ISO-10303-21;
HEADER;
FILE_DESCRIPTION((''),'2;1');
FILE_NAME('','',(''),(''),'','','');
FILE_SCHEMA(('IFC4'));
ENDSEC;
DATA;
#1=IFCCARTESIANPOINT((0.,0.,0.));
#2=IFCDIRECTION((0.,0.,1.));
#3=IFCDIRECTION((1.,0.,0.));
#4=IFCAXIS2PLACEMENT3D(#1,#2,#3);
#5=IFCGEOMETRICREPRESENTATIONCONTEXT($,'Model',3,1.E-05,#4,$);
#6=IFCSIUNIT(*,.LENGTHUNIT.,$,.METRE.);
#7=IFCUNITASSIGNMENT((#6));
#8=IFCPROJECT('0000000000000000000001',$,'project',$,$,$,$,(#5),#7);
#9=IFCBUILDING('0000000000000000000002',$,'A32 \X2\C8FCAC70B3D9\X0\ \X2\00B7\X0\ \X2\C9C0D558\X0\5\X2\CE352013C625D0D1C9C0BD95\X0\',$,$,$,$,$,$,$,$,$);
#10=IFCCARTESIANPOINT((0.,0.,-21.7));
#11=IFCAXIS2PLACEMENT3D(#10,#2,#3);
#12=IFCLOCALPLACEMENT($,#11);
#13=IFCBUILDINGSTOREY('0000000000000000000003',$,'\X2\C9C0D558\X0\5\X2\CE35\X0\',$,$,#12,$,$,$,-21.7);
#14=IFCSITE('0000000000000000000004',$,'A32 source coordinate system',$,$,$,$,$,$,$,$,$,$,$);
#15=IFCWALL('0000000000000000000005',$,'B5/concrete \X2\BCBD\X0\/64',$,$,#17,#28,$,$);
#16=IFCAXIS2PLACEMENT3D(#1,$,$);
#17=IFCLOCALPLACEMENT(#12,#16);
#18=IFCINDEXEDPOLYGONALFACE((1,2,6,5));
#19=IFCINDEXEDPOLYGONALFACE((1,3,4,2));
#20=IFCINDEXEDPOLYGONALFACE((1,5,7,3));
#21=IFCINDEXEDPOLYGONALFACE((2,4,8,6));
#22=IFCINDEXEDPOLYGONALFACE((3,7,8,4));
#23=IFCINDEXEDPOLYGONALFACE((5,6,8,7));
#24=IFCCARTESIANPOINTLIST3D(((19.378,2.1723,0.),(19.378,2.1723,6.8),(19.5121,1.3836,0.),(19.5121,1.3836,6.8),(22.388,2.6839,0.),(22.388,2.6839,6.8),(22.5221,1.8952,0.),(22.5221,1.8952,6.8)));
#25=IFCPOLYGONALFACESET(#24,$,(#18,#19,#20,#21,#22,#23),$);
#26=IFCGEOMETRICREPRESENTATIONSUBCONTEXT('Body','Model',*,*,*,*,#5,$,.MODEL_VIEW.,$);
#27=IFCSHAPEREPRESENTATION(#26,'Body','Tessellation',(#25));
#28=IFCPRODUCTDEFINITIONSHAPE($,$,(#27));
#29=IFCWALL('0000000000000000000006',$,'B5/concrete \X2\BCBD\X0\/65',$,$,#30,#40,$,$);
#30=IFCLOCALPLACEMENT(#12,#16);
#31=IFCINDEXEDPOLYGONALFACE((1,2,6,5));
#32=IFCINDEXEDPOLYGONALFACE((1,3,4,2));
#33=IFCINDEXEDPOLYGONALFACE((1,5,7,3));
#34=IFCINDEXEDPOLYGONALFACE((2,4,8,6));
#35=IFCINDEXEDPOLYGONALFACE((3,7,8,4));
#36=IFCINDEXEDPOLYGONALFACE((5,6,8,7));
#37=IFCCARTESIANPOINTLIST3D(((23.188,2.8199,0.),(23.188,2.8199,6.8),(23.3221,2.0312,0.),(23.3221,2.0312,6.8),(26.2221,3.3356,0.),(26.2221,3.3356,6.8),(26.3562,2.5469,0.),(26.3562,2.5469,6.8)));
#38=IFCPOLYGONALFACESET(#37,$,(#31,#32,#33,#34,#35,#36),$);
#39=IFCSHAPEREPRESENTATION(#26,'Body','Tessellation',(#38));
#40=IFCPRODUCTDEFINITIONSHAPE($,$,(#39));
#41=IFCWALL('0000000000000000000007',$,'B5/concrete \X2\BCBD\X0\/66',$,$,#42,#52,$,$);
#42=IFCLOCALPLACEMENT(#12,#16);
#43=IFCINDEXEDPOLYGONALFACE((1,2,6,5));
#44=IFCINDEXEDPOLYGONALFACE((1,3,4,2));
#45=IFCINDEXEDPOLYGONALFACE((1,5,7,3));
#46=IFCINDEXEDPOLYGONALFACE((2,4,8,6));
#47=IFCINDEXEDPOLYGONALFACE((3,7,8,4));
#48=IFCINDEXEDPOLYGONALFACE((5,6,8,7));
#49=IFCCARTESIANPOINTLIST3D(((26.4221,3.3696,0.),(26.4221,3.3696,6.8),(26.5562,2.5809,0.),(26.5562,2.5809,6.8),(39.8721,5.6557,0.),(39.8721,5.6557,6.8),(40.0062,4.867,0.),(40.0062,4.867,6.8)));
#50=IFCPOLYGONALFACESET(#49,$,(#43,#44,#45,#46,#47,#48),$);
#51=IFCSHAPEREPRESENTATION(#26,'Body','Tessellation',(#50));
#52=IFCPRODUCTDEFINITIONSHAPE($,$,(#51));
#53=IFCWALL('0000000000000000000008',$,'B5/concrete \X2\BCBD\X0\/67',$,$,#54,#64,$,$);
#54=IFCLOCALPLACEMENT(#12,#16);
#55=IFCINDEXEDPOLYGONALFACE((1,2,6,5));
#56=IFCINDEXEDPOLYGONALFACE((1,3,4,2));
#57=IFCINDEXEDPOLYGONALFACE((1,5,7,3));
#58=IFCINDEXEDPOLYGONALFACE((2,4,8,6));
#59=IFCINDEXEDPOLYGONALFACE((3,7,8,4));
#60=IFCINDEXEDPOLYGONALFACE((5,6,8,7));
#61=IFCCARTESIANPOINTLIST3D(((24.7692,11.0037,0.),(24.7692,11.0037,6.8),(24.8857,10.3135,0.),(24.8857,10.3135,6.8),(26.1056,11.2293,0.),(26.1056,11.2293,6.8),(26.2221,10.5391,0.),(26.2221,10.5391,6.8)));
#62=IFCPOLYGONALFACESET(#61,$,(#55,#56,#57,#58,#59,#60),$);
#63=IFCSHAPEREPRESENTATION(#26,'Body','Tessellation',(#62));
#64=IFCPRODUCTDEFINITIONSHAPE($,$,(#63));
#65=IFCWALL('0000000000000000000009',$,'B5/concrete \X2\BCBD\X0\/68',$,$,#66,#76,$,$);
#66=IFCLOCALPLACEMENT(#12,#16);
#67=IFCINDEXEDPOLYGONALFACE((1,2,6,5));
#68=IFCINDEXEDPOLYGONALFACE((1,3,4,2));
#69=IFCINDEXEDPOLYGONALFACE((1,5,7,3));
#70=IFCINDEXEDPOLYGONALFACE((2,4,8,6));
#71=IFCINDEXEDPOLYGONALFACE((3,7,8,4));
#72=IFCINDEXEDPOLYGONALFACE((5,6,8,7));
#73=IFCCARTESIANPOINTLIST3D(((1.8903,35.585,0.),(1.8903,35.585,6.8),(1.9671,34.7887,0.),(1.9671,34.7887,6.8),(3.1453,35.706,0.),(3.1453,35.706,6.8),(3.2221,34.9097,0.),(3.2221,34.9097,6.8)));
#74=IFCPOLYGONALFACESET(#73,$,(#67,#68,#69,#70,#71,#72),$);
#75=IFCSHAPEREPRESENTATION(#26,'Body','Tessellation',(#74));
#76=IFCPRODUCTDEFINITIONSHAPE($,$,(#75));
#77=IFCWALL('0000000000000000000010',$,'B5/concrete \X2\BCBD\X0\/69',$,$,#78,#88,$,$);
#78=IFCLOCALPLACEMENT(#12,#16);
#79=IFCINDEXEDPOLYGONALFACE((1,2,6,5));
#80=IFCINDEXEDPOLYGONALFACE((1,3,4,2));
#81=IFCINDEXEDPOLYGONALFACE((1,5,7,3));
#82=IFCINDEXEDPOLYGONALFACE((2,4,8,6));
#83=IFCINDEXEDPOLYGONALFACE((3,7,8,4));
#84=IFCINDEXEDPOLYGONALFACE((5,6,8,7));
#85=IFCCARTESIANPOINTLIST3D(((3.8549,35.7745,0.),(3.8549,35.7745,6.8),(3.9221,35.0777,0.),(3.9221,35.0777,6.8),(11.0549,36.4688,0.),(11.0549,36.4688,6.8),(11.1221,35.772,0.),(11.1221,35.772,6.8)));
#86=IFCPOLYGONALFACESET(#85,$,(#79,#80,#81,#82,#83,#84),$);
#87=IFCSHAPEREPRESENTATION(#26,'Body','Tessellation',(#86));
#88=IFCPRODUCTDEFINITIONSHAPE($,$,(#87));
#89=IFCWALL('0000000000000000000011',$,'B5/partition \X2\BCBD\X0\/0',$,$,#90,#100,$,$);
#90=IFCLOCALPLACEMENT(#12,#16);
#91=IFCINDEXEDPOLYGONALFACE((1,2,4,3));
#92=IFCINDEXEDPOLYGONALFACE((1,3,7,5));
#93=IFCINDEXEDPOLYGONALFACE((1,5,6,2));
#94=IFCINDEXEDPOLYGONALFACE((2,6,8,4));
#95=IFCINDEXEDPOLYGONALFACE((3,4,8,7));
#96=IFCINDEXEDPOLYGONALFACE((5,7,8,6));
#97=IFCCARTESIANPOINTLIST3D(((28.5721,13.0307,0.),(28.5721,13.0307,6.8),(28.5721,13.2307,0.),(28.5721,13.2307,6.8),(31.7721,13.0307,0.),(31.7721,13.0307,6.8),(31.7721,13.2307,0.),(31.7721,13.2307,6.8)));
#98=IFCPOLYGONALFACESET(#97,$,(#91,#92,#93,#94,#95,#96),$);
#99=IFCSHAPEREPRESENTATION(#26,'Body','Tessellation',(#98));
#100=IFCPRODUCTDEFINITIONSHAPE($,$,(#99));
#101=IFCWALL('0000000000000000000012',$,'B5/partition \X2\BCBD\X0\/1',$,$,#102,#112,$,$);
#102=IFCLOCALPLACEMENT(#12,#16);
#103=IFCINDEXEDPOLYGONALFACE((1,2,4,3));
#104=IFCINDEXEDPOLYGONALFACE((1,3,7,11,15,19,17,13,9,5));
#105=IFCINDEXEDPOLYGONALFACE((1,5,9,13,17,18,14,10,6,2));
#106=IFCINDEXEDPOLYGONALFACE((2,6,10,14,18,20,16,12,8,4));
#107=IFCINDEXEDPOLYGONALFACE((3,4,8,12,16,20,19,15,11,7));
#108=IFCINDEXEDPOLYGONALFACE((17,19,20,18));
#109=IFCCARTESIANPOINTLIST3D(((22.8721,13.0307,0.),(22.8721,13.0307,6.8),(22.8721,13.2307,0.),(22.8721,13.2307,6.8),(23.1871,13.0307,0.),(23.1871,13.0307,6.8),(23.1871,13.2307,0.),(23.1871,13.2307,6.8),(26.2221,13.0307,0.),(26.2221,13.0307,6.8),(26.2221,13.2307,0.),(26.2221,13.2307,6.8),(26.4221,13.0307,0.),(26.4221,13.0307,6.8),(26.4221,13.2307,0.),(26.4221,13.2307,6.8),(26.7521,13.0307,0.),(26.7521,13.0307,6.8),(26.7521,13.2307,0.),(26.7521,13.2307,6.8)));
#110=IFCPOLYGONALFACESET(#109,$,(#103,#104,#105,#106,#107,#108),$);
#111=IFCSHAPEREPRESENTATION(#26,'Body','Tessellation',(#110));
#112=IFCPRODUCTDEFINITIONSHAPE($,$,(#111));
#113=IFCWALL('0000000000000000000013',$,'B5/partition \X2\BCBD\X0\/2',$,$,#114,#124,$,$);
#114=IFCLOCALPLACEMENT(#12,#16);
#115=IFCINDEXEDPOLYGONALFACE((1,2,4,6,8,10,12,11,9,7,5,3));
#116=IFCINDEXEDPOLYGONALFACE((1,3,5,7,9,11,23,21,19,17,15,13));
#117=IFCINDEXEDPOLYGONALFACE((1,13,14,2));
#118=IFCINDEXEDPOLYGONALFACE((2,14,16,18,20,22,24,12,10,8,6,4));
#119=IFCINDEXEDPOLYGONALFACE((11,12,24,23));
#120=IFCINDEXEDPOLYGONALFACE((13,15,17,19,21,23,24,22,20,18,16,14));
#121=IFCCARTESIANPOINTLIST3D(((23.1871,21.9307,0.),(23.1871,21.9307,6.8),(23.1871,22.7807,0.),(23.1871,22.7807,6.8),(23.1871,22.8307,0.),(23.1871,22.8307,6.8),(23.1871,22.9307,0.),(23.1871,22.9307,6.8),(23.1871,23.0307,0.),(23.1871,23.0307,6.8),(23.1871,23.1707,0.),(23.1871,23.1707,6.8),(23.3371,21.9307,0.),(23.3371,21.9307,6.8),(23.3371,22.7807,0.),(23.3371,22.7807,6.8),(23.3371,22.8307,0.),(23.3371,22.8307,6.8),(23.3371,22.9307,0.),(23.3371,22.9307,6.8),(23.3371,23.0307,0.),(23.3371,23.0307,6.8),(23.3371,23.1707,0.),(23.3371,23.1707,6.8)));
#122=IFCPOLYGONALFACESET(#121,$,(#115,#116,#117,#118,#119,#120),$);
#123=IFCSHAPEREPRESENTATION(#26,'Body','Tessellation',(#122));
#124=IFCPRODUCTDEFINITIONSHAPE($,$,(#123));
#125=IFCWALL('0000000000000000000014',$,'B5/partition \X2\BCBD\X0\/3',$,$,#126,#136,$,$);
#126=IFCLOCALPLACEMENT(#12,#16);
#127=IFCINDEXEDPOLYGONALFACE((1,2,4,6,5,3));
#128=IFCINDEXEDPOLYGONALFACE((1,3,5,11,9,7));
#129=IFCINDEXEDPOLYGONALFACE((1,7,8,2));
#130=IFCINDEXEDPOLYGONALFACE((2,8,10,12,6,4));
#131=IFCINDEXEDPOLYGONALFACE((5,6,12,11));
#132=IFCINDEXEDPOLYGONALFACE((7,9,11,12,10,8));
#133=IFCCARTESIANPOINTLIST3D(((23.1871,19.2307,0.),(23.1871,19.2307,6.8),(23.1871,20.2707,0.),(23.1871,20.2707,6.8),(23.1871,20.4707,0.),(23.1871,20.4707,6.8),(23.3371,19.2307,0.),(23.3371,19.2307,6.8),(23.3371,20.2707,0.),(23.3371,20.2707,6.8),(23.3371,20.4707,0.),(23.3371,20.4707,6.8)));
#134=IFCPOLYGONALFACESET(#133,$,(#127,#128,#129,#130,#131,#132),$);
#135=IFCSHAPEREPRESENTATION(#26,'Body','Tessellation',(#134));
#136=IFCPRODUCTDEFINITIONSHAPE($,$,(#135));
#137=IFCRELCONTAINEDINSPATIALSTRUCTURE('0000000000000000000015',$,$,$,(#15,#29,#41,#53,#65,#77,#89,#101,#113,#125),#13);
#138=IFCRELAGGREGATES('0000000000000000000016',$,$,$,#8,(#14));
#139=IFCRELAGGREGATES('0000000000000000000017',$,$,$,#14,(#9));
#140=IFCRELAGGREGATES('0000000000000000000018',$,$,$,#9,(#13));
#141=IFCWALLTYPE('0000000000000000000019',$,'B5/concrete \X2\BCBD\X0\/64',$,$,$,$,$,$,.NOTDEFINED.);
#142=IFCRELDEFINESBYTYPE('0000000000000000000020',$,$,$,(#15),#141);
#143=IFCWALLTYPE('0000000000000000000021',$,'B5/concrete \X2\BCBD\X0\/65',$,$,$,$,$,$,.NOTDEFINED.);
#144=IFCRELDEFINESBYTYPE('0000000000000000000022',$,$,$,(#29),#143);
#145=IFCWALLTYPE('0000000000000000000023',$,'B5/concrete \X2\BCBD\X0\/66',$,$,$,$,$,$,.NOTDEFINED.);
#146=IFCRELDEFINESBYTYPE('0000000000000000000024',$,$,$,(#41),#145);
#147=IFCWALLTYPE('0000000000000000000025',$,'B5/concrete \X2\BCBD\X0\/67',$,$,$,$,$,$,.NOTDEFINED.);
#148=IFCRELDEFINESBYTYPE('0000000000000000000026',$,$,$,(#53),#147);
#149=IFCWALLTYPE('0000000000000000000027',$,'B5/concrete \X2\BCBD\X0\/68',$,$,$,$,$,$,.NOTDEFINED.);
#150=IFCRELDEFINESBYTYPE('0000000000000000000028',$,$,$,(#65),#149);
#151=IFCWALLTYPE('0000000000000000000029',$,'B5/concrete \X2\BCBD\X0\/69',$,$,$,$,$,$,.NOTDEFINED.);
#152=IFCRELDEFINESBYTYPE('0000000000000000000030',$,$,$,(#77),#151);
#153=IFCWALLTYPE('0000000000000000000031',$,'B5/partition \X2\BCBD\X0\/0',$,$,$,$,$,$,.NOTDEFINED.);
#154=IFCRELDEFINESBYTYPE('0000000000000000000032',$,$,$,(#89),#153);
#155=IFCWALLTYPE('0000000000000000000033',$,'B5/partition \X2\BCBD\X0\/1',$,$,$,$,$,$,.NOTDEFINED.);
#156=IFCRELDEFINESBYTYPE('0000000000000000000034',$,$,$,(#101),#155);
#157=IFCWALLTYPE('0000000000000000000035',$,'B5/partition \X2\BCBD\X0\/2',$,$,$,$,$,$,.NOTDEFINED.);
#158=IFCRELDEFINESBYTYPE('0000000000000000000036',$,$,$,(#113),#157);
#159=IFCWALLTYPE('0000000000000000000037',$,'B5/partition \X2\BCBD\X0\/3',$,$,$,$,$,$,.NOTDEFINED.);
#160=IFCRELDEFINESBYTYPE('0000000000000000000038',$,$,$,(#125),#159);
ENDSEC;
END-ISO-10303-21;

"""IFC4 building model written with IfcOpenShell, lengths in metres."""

from ifc_helpers import new_model, si_unit, frame, origin, origin_with_axes, place, context, subcontext, project, spatial, polyline, outline, extrude, source, transform, mapped, type_object, type_shapes, element, save


model = new_model("IFC4")

# Units and contexts
model_context = context("Model", 3, precision=1e-05, world=origin_with_axes())
body_context = subcontext(model_context, "Body", "Model", "MODEL_VIEW")
ifc_project = project(units=[si_unit("LENGTHUNIT", "METRE")], contexts=[model_context])

# Site, building, storey
site = spatial("IfcSite", under=ifc_project, Name="A32 source coordinate system")
building = spatial("IfcBuilding", under=site, Name="A32 주거동 · 지하5층–옥탑지붕")
storey_placement = place(None, frame((0.0, 0.0, -21.7), z_axis=(0.0, 0.0, 1.0), x_axis=(1.0, 0.0, 0.0)))
storey = spatial("IfcBuildingStorey", under=building, at=storey_placement, Name="지하5층", Elevation=-21.7)

# Walls
wall_type_1 = type_object("IfcWallType", Name="B5/concrete 벽/64", PredefinedType="NOTDEFINED")
shared_shape_1 = source(origin(), body_context, "Body", "SweptSolid", [
    extrude(outline(polyline([(19.5121, 1.3836), (19.378, 2.1723), (22.388, 2.6839), (22.5221, 1.8952), (19.5121, 1.3836)])), origin(), (0.0, 0.0, 1.0), 6.8),
])
type_shapes(wall_type_1, [shared_shape_1])
wall_1_placement = place(storey_placement, origin_with_axes())
element("IfcWall", 1, at=wall_1_placement, inside=storey, type_object=wall_type_1, Name="B5/concrete 벽/64", context=body_context, shape_type="MappedRepresentation", body=[
    mapped(shared_shape_1, transform((0.0, 0.0, 0.0), scale=1.0)),
])
wall_type_2 = type_object("IfcWallType", Name="B5/concrete 벽/65", PredefinedType="NOTDEFINED")
shared_shape_2 = source(origin(), body_context, "Body", "SweptSolid", [
    extrude(outline(polyline([(23.188, 2.8199), (26.2221, 3.3356), (26.3562, 2.5469), (23.3221, 2.0312), (23.188, 2.8199)])), origin(), (0.0, 0.0, 1.0), 6.8),
])
type_shapes(wall_type_2, [shared_shape_2])
wall_2_placement = place(storey_placement, origin_with_axes())
element("IfcWall", 2, at=wall_2_placement, inside=storey, type_object=wall_type_2, Name="B5/concrete 벽/65", context=body_context, shape_type="MappedRepresentation", body=[
    mapped(shared_shape_2, transform((0.0, 0.0, 0.0), scale=1.0)),
])
wall_type_3 = type_object("IfcWallType", Name="B5/concrete 벽/66", PredefinedType="NOTDEFINED")
shared_shape_3 = source(origin(), body_context, "Body", "SweptSolid", [
    extrude(outline(polyline([(26.4221, 3.3696), (39.8721, 5.6557), (40.0062, 4.867), (26.5562, 2.5809), (26.4221, 3.3696)])), origin(), (0.0, 0.0, 1.0), 6.8),
])
type_shapes(wall_type_3, [shared_shape_3])
wall_3_placement = place(storey_placement, origin_with_axes())
element("IfcWall", 3, at=wall_3_placement, inside=storey, type_object=wall_type_3, Name="B5/concrete 벽/66", context=body_context, shape_type="MappedRepresentation", body=[
    mapped(shared_shape_3, transform((0.0, 0.0, 0.0), scale=1.0)),
])
wall_type_4 = type_object("IfcWallType", Name="B5/concrete 벽/67", PredefinedType="NOTDEFINED")
shared_shape_4 = source(origin(), body_context, "Body", "SweptSolid", [
    extrude(outline(polyline([(24.7692, 11.0037), (26.1056, 11.2293), (26.2221, 10.5391), (24.8857, 10.3135), (24.7692, 11.0037)])), origin(), (0.0, 0.0, 1.0), 6.8),
])
type_shapes(wall_type_4, [shared_shape_4])
wall_4_placement = place(storey_placement, origin_with_axes())
element("IfcWall", 4, at=wall_4_placement, inside=storey, type_object=wall_type_4, Name="B5/concrete 벽/67", context=body_context, shape_type="MappedRepresentation", body=[
    mapped(shared_shape_4, transform((0.0, 0.0, 0.0), scale=1.0)),
])
wall_type_5 = type_object("IfcWallType", Name="B5/concrete 벽/68", PredefinedType="NOTDEFINED")
shared_shape_5 = source(origin(), body_context, "Body", "SweptSolid", [
    extrude(outline(polyline([(3.2221, 34.9097), (1.9671, 34.7887), (1.8903, 35.585), (3.1453, 35.706), (3.2221, 34.9097)])), origin(), (0.0, 0.0, 1.0), 6.8),
])
type_shapes(wall_type_5, [shared_shape_5])
wall_5_placement = place(storey_placement, origin_with_axes())
element("IfcWall", 5, at=wall_5_placement, inside=storey, type_object=wall_type_5, Name="B5/concrete 벽/68", context=body_context, shape_type="MappedRepresentation", body=[
    mapped(shared_shape_5, transform((0.0, 0.0, 0.0), scale=1.0)),
])
wall_type_6 = type_object("IfcWallType", Name="B5/concrete 벽/69", PredefinedType="NOTDEFINED")
shared_shape_6 = source(origin(), body_context, "Body", "SweptSolid", [
    extrude(outline(polyline([(3.9221, 35.0777), (3.8549, 35.7745), (11.0549, 36.4688), (11.1221, 35.772), (3.9221, 35.0777)])), origin(), (0.0, 0.0, 1.0), 6.8),
])
type_shapes(wall_type_6, [shared_shape_6])
wall_6_placement = place(storey_placement, origin_with_axes())
element("IfcWall", 6, at=wall_6_placement, inside=storey, type_object=wall_type_6, Name="B5/concrete 벽/69", context=body_context, shape_type="MappedRepresentation", body=[
    mapped(shared_shape_6, transform((0.0, 0.0, 0.0), scale=1.0)),
])
wall_type_7 = type_object("IfcWallType", Name="B5/partition 벽/0", PredefinedType="NOTDEFINED")
shared_shape_7 = source(origin(), body_context, "Body", "SweptSolid", [
    extrude(outline(polyline([(28.5721, 13.2307), (31.7721, 13.2307), (31.7721, 13.0307), (28.5721, 13.0307), (28.5721, 13.2307)])), origin(), (0.0, 0.0, 1.0), 6.8),
])
type_shapes(wall_type_7, [shared_shape_7])
wall_7_placement = place(storey_placement, origin_with_axes())
element("IfcWall", 7, at=wall_7_placement, inside=storey, type_object=wall_type_7, Name="B5/partition 벽/0", context=body_context, shape_type="MappedRepresentation", body=[
    mapped(shared_shape_7, transform((0.0, 0.0, 0.0), scale=1.0)),
])
wall_type_8 = type_object("IfcWallType", Name="B5/partition 벽/1", PredefinedType="NOTDEFINED")
shared_shape_8 = source(origin(), body_context, "Body", "SweptSolid", [
    extrude(outline(polyline([(26.2221, 13.2307), (26.4221, 13.2307), (26.7521, 13.2307), (26.7521, 13.0307), (26.4221, 13.0307), (26.2221, 13.0307), (23.1871, 13.0307), (22.8721, 13.0307), (22.8721, 13.2307), (23.1871, 13.2307), (26.2221, 13.2307)])), origin(), (0.0, 0.0, 1.0), 6.8),
])
type_shapes(wall_type_8, [shared_shape_8])
wall_8_placement = place(storey_placement, origin_with_axes())
element("IfcWall", 8, at=wall_8_placement, inside=storey, type_object=wall_type_8, Name="B5/partition 벽/1", context=body_context, shape_type="MappedRepresentation", body=[
    mapped(shared_shape_8, transform((0.0, 0.0, 0.0), scale=1.0)),
])
wall_type_9 = type_object("IfcWallType", Name="B5/partition 벽/2", PredefinedType="NOTDEFINED")
shared_shape_9 = source(origin(), body_context, "Body", "SweptSolid", [
    extrude(outline(polyline([(23.1871, 23.1707), (23.3371, 23.1707), (23.3371, 23.0307), (23.3371, 22.9307), (23.3371, 22.8307), (23.3371, 22.7807), (23.3371, 21.9307), (23.1871, 21.9307), (23.1871, 22.7807), (23.1871, 22.8307), (23.1871, 22.9307), (23.1871, 23.0307), (23.1871, 23.1707)])), origin(), (0.0, 0.0, 1.0), 6.8),
])
type_shapes(wall_type_9, [shared_shape_9])
wall_9_placement = place(storey_placement, origin_with_axes())
element("IfcWall", 9, at=wall_9_placement, inside=storey, type_object=wall_type_9, Name="B5/partition 벽/2", context=body_context, shape_type="MappedRepresentation", body=[
    mapped(shared_shape_9, transform((0.0, 0.0, 0.0), scale=1.0)),
])
wall_type_10 = type_object("IfcWallType", Name="B5/partition 벽/3", PredefinedType="NOTDEFINED")
shared_shape_10 = source(origin(), body_context, "Body", "SweptSolid", [
    extrude(outline(polyline([(23.1871, 19.2307), (23.1871, 20.2707), (23.1871, 20.4707), (23.3371, 20.4707), (23.3371, 20.2707), (23.3371, 19.2307), (23.1871, 19.2307)])), origin(), (0.0, 0.0, 1.0), 6.8),
])
type_shapes(wall_type_10, [shared_shape_10])
wall_10_placement = place(storey_placement, origin_with_axes())
element("IfcWall", 10, at=wall_10_placement, inside=storey, type_object=wall_type_10, Name="B5/partition 벽/3", context=body_context, shape_type="MappedRepresentation", body=[
    mapped(shared_shape_10, transform((0.0, 0.0, 0.0), scale=1.0)),
])

save(model, "model.ifc")
